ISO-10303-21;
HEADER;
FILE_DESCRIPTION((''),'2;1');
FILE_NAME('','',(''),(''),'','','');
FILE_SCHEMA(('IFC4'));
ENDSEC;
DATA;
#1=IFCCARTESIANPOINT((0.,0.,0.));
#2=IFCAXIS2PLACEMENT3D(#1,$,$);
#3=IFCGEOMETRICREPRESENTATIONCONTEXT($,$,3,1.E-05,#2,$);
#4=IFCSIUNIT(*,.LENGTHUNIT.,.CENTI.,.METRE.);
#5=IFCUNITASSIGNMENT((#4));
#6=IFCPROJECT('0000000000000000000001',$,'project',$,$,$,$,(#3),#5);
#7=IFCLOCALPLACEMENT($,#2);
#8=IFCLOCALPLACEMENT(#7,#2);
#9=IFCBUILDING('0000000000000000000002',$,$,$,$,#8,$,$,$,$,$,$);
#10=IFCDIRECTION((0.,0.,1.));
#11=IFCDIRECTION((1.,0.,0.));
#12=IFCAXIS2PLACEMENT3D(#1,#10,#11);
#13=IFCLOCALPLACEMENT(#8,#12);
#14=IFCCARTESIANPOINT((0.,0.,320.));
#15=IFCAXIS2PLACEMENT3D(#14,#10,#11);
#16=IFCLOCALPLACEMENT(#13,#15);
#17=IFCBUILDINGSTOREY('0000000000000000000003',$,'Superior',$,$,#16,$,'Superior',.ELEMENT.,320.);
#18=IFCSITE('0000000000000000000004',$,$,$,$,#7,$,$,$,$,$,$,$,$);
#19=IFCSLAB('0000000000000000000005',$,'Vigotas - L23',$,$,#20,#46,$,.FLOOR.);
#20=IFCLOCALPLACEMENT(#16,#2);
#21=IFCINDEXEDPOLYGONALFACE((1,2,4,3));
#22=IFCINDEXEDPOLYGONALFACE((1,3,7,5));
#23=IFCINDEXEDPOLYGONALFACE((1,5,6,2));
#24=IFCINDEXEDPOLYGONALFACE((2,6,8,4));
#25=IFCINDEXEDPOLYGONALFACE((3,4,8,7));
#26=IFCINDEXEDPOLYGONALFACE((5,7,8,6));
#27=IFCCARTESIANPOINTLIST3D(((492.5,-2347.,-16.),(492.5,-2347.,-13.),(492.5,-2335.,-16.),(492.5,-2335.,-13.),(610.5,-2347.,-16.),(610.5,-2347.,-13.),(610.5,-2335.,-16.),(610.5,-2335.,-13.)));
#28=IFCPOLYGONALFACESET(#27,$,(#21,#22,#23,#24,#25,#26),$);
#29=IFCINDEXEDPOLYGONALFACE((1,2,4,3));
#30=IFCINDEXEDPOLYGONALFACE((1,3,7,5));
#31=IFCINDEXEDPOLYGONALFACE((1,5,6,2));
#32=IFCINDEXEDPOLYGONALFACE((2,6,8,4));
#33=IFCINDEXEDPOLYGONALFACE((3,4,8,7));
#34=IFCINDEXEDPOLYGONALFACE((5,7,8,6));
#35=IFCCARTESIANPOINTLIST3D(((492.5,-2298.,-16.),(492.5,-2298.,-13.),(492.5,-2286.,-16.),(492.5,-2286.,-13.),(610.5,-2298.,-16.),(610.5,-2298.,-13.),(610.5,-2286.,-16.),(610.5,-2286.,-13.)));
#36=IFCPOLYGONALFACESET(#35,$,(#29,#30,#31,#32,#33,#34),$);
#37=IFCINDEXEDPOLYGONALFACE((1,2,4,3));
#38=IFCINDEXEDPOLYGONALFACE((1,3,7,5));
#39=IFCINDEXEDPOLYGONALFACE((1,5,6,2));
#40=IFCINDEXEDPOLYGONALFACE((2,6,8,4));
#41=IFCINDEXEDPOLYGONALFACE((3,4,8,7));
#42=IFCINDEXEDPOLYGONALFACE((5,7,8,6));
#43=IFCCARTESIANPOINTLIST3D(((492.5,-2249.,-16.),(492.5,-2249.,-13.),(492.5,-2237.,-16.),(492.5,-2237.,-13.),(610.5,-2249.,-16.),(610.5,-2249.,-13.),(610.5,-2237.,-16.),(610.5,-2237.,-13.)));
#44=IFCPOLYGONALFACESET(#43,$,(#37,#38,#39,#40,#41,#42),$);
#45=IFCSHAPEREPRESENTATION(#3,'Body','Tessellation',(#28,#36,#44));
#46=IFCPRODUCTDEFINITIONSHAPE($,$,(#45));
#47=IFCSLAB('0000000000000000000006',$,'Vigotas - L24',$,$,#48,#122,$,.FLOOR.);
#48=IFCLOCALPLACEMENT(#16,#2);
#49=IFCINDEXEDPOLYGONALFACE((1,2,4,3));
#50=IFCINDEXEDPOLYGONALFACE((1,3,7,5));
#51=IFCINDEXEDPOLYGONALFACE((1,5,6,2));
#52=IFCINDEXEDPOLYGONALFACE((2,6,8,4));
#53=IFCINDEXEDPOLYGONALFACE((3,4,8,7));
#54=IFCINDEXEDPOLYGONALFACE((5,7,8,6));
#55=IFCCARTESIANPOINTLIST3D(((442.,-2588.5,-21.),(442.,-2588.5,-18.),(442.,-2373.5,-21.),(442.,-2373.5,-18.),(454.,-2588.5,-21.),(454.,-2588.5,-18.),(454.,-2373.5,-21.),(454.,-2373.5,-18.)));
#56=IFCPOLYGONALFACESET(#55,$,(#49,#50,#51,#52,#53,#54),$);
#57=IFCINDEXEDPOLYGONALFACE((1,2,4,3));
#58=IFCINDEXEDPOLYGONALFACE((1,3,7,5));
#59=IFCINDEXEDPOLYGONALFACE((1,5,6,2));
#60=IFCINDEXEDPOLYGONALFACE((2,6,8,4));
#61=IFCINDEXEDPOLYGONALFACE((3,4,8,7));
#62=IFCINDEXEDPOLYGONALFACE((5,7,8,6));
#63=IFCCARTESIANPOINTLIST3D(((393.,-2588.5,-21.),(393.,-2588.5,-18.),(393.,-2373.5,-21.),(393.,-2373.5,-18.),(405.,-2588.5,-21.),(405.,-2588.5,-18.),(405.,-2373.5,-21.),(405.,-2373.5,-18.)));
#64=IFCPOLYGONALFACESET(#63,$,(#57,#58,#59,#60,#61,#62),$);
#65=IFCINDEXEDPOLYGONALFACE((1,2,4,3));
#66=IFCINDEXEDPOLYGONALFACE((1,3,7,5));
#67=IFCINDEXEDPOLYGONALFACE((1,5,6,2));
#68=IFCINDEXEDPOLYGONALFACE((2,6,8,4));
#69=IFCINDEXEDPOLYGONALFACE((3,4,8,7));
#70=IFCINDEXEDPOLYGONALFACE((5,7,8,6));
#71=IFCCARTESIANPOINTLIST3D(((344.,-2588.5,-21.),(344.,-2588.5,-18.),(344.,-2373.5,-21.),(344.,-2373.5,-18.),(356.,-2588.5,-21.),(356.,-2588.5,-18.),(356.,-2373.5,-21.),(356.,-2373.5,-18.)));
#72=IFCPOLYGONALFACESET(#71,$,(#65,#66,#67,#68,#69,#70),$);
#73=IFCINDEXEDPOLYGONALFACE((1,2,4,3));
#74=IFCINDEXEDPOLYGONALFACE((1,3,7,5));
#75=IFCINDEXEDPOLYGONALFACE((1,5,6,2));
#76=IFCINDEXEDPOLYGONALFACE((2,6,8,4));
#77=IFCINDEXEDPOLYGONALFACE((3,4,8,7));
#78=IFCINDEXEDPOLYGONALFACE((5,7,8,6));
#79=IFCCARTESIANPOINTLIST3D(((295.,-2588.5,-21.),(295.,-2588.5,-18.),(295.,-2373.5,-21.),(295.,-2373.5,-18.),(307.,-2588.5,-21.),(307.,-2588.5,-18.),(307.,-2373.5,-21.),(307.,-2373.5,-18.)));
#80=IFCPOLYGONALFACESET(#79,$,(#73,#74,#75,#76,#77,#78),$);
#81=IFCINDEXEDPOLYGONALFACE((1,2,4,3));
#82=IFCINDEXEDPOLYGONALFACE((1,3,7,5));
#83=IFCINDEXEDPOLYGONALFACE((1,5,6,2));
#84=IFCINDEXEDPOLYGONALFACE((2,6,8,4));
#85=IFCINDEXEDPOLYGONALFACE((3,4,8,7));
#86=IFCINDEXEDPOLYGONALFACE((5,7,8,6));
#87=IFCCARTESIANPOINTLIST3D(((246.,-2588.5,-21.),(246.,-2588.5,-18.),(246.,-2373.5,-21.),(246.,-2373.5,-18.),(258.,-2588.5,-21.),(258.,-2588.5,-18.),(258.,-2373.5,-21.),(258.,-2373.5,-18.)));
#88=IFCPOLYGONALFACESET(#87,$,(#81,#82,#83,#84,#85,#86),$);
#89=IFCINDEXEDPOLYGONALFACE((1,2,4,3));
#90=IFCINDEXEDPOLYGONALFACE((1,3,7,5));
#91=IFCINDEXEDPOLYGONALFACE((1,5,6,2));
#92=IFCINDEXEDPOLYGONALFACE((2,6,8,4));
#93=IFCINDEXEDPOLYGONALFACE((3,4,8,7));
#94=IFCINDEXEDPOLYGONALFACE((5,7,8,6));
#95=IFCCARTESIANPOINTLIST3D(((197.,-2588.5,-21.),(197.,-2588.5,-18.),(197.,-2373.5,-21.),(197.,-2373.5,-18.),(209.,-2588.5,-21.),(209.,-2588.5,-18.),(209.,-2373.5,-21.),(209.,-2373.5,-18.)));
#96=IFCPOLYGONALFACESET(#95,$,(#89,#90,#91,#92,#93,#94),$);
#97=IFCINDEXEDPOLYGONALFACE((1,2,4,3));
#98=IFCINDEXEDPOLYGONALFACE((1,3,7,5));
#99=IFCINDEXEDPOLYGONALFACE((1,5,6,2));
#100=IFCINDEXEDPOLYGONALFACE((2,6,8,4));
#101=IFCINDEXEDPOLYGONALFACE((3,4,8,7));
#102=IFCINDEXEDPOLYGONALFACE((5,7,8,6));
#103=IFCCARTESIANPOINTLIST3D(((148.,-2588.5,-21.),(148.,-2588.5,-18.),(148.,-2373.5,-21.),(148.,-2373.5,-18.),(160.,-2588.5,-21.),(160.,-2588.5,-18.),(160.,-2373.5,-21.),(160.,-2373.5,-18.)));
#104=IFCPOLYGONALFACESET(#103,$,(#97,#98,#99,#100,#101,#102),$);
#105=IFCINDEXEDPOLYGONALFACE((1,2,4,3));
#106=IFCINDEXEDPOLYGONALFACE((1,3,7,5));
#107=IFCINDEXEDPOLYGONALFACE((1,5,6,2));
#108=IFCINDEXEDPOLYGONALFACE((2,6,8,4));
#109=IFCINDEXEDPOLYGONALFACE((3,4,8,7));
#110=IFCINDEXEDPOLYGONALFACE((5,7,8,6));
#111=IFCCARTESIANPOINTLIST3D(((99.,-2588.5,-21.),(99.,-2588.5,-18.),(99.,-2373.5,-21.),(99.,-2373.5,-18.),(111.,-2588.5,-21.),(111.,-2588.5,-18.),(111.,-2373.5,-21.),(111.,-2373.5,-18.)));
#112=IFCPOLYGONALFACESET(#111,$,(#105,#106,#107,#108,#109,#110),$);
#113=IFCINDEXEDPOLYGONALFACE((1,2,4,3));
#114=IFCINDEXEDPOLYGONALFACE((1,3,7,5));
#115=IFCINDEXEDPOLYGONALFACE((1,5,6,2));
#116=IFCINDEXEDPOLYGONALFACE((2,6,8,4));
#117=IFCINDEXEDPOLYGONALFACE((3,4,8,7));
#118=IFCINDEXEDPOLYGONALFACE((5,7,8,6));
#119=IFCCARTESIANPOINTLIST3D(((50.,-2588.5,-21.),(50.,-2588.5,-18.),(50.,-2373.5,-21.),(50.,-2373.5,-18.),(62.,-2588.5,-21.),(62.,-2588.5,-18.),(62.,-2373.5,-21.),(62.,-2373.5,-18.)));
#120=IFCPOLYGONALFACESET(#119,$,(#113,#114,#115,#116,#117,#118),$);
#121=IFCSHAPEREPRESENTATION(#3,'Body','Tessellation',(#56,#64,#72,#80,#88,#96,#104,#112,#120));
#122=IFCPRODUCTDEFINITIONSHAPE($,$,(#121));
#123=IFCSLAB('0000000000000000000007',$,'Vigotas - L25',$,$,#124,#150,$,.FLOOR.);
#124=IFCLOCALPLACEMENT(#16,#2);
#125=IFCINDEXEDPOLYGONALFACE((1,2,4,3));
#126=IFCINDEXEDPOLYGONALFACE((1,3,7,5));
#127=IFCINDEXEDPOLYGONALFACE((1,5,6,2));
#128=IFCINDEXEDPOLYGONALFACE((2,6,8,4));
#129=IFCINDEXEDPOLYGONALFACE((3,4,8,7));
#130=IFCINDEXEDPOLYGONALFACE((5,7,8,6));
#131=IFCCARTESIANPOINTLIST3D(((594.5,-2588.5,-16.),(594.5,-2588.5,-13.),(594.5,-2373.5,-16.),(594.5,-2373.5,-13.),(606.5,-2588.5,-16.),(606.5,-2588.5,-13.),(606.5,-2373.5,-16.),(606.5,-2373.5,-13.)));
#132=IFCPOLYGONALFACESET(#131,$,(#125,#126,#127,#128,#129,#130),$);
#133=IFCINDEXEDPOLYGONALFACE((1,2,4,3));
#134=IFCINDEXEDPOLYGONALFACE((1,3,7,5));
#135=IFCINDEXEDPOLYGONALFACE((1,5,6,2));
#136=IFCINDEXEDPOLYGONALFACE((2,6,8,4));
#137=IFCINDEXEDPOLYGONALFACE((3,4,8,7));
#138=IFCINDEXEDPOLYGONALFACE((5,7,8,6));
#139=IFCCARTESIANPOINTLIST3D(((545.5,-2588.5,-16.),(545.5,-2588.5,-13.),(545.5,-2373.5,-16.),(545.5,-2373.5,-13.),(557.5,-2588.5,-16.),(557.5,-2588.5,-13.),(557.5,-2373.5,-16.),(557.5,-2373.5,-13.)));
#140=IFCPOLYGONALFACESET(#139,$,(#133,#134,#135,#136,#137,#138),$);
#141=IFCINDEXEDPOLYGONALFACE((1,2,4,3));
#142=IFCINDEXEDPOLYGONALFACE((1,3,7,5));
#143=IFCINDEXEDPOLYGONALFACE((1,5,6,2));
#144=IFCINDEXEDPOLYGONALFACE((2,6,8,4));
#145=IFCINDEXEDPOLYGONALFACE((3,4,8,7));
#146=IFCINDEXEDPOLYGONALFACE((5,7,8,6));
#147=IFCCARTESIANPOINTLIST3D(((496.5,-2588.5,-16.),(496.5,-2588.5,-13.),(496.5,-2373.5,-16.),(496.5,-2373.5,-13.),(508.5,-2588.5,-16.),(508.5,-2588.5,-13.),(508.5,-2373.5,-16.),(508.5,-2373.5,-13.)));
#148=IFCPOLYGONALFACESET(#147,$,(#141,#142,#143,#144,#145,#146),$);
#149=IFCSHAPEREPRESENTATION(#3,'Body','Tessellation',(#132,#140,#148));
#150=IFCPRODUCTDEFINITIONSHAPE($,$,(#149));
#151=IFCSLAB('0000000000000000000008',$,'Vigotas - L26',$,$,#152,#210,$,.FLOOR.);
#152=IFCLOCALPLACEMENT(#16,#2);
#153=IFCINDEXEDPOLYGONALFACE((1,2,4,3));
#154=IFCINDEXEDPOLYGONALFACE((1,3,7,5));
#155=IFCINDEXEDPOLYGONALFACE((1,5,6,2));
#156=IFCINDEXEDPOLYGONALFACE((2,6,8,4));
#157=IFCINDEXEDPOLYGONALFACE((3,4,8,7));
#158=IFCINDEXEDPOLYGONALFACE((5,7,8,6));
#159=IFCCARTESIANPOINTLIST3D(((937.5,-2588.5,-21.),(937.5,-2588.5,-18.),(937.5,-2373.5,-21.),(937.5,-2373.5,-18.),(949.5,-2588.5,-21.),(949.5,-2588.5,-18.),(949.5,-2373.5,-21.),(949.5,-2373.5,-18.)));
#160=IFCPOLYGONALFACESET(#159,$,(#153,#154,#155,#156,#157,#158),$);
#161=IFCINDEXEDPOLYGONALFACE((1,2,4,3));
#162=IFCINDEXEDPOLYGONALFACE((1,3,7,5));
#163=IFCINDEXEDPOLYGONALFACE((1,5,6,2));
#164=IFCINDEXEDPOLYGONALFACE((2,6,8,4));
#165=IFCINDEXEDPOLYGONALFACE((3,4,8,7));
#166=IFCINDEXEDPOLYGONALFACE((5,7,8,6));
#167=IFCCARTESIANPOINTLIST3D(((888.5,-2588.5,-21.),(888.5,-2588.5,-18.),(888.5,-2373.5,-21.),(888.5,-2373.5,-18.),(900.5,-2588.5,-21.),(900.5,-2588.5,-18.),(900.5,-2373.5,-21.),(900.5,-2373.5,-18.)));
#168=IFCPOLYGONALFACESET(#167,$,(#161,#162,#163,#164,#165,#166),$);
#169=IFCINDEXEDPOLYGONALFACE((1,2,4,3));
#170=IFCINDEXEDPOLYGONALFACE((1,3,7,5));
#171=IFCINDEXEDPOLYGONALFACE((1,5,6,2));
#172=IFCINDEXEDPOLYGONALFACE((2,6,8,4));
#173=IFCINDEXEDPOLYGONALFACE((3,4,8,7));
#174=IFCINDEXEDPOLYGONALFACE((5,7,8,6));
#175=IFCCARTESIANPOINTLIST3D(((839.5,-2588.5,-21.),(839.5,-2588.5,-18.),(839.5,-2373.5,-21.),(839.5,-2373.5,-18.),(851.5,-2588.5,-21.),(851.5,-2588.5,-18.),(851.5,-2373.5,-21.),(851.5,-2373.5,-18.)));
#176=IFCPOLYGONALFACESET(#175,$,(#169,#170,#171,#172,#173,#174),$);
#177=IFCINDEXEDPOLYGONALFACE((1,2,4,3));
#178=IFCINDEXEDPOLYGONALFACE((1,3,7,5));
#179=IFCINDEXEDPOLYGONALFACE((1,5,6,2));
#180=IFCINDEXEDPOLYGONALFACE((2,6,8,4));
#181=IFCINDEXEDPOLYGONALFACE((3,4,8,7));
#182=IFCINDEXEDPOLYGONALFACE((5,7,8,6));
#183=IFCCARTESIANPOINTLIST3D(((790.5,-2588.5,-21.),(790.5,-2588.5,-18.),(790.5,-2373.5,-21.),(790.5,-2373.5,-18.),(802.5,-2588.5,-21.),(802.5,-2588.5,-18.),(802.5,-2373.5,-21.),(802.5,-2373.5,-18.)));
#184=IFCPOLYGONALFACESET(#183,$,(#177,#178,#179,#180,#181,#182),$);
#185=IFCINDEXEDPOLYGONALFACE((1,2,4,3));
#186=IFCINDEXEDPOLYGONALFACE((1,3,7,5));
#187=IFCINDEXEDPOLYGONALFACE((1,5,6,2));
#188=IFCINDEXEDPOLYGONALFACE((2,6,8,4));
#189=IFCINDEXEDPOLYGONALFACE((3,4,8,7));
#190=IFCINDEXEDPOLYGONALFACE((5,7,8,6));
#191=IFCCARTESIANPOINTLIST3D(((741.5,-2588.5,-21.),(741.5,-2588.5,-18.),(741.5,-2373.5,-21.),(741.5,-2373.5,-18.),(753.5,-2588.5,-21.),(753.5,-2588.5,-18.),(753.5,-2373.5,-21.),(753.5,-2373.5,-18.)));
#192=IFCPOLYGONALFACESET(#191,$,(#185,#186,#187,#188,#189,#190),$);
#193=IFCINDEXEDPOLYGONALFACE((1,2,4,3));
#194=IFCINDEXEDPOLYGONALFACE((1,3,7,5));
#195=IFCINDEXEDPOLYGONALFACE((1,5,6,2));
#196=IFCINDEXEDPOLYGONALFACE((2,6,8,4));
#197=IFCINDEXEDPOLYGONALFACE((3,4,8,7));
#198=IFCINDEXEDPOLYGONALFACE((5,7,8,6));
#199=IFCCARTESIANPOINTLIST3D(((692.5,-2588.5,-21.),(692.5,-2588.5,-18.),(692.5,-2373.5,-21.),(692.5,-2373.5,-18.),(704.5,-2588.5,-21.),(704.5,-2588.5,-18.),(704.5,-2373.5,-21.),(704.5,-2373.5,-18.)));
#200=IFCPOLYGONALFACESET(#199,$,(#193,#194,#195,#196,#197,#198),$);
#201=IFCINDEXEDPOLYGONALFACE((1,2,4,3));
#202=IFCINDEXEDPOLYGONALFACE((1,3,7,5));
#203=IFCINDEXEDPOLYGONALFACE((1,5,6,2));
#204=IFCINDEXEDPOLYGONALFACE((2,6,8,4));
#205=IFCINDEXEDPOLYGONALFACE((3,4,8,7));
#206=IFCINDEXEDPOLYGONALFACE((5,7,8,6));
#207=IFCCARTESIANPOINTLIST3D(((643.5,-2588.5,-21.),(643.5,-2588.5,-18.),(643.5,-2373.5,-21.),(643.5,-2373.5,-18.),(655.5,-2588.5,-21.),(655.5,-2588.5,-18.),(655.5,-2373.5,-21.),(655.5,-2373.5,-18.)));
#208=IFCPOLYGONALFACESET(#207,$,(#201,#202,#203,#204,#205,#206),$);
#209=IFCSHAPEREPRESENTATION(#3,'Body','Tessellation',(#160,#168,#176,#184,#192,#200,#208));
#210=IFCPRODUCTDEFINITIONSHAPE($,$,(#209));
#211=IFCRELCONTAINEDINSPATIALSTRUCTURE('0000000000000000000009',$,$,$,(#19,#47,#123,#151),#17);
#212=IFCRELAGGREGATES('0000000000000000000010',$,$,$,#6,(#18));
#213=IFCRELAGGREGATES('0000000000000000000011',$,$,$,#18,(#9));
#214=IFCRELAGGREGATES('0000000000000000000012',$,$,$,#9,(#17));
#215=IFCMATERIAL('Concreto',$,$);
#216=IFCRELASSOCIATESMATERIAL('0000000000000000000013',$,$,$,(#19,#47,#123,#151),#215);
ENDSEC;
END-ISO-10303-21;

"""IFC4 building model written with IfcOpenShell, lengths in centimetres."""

from ifc_helpers import new_model, si_unit, frame, origin, origin_with_axes, place, context, project, spatial, polyline, outline, extrude, material, element, save


model = new_model("IFC4")

# Units and contexts
context_of_model = context(None, 3, precision=1e-05, world=origin())
ifc_project = project(units=[si_unit("LENGTHUNIT", "METRE", prefix="CENTI")], contexts=[context_of_model])

# Site, building, storey
site_placement = place(None, origin())
site = spatial("IfcSite", under=ifc_project, at=site_placement)
building_placement = place(site_placement, origin())
building = spatial("IfcBuilding", under=site, at=building_placement)
placement = place(building_placement, origin_with_axes())
storey_placement = place(placement, frame((0.0, 0.0, 320.0), z_axis=(0.0, 0.0, 1.0), x_axis=(1.0, 0.0, 0.0)))
storey = spatial("IfcBuildingStorey", under=building, at=storey_placement, Name="Superior", LongName="Superior", CompositionType="ELEMENT", Elevation=320.0)

# Shared definitions
ifc_material = material(Name="Concreto")

# Slabs
slab_1_placement = place(storey_placement, frame((551.5, -2292.0, -13.0), z_axis=(0.0, 0.0, 1.0), x_axis=(1.0, 0.0, 0.0)))
element("IfcSlab", 1, at=slab_1_placement, inside=storey, material=ifc_material, Name="Vigotas - L23", PredefinedType="FLOOR", context=context_of_model, shape_type="SolidModel", body=[
    extrude(outline(polyline([(6.0, 1.5), (-6.0, 1.5), (-6.0, -1.5), (6.0, -1.5), (6.0, 1.5), (6.0, 1.5)])), frame((-59.0, -49.0, -1.5), z_axis=(1.0, 0.0, 0.0), x_axis=(0.0, -1.0, 0.0)), (0.0, 0.0, 1.0), 118.0),
    extrude(outline(polyline([(6.0, 1.5), (-6.0, 1.5), (-6.0, -1.5), (6.0, -1.5), (6.0, 1.5), (6.0, 1.5)])), frame((-59.0, 0.0, -1.5), z_axis=(1.0, 0.0, 0.0), x_axis=(0.0, -1.0, 0.0)), (0.0, 0.0, 1.0), 118.0),
    extrude(outline(polyline([(6.0, 1.5), (-6.0, 1.5), (-6.0, -1.5), (6.0, -1.5), (6.0, 1.5), (6.0, 1.5)])), frame((-59.0, 49.0, -1.5), z_axis=(1.0, 0.0, 0.0), x_axis=(0.0, -1.0, 0.0)), (0.0, 0.0, 1.0), 118.0),
])
slab_2_placement = place(storey_placement, frame((252.0, -2481.0, -18.0), z_axis=(0.0, 0.0, 1.0), x_axis=(1.0, 0.0, 0.0)))
element("IfcSlab", 2, at=slab_2_placement, inside=storey, material=ifc_material, Name="Vigotas - L24", PredefinedType="FLOOR", context=context_of_model, shape_type="SolidModel", body=[
    extrude(outline(polyline([(6.0, 1.5), (-6.0, 1.5), (-6.0, -1.5), (6.0, -1.5), (6.0, 1.5), (6.0, 1.5)])), frame((196.0, -107.5, -1.5), z_axis=(0.0, 1.0, 0.0), x_axis=(1.0, 0.0, 0.0)), (0.0, 0.0, 1.0), 215.0),
    extrude(outline(polyline([(6.0, 1.5), (-6.0, 1.5), (-6.0, -1.5), (6.0, -1.5), (6.0, 1.5), (6.0, 1.5)])), frame((147.0, -107.5, -1.5), z_axis=(0.0, 1.0, 0.0), x_axis=(1.0, 0.0, 0.0)), (0.0, 0.0, 1.0), 215.0),
    extrude(outline(polyline([(6.0, 1.5), (-6.0, 1.5), (-6.0, -1.5), (6.0, -1.5), (6.0, 1.5), (6.0, 1.5)])), frame((98.0, -107.5, -1.5), z_axis=(0.0, 1.0, 0.0), x_axis=(1.0, 0.0, 0.0)), (0.0, 0.0, 1.0), 215.0),
    extrude(outline(polyline([(6.0, 1.5), (-6.0, 1.5), (-6.0, -1.5), (6.0, -1.5), (6.0, 1.5), (6.0, 1.5)])), frame((49.0, -107.5, -1.5), z_axis=(0.0, 1.0, 0.0), x_axis=(1.0, 0.0, 0.0)), (0.0, 0.0, 1.0), 215.0),
    extrude(outline(polyline([(6.0, 1.5), (-6.0, 1.5), (-6.0, -1.5), (6.0, -1.5), (6.0, 1.5), (6.0, 1.5)])), frame((0.0, -107.5, -1.5), z_axis=(0.0, 1.0, 0.0), x_axis=(1.0, 0.0, 0.0)), (0.0, 0.0, 1.0), 215.0),
    extrude(outline(polyline([(6.0, 1.5), (-6.0, 1.5), (-6.0, -1.5), (6.0, -1.5), (6.0, 1.5), (6.0, 1.5)])), frame((-49.0, -107.5, -1.5), z_axis=(0.0, 1.0, 0.0), x_axis=(1.0, 0.0, 0.0)), (0.0, 0.0, 1.0), 215.0),
    extrude(outline(polyline([(6.0, 1.5), (-6.0, 1.5), (-6.0, -1.5), (6.0, -1.5), (6.0, 1.5), (6.0, 1.5)])), frame((-98.0, -107.5, -1.5), z_axis=(0.0, 1.0, 0.0), x_axis=(1.0, 0.0, 0.0)), (0.0, 0.0, 1.0), 215.0),
    extrude(outline(polyline([(6.0, 1.5), (-6.0, 1.5), (-6.0, -1.5), (6.0, -1.5), (6.0, 1.5), (6.0, 1.5)])), frame((-147.0, -107.5, -1.5), z_axis=(0.0, 1.0, 0.0), x_axis=(1.0, 0.0, 0.0)), (0.0, 0.0, 1.0), 215.0),
    extrude(outline(polyline([(6.0, 1.5), (-6.0, 1.5), (-6.0, -1.5), (6.0, -1.5), (6.0, 1.5), (6.0, 1.5)])), frame((-196.0, -107.5, -1.5), z_axis=(0.0, 1.0, 0.0), x_axis=(1.0, 0.0, 0.0)), (0.0, 0.0, 1.0), 215.0),
])
slab_3_placement = place(storey_placement, frame((551.5, -2481.0, -13.0), z_axis=(0.0, 0.0, 1.0), x_axis=(1.0, 0.0, 0.0)))
element("IfcSlab", 3, at=slab_3_placement, inside=storey, material=ifc_material, Name="Vigotas - L25", PredefinedType="FLOOR", context=context_of_model, shape_type="SolidModel", body=[
    extrude(outline(polyline([(6.0, 1.5), (-6.0, 1.5), (-6.0, -1.5), (6.0, -1.5), (6.0, 1.5), (6.0, 1.5)])), frame((49.0, -107.5, -1.5), z_axis=(0.0, 1.0, 0.0), x_axis=(1.0, 0.0, 0.0)), (0.0, 0.0, 1.0), 215.0),
    extrude(outline(polyline([(6.0, 1.5), (-6.0, 1.5), (-6.0, -1.5), (6.0, -1.5), (6.0, 1.5), (6.0, 1.5)])), frame((0.0, -107.5, -1.5), z_axis=(0.0, 1.0, 0.0), x_axis=(1.0, 0.0, 0.0)), (0.0, 0.0, 1.0), 215.0),
    extrude(outline(polyline([(6.0, 1.5), (-6.0, 1.5), (-6.0, -1.5), (6.0, -1.5), (6.0, 1.5), (6.0, 1.5)])), frame((-49.0, -107.5, -1.5), z_axis=(0.0, 1.0, 0.0), x_axis=(1.0, 0.0, 0.0)), (0.0, 0.0, 1.0), 215.0),
])
slab_4_placement = place(storey_placement, frame((796.5, -2481.0, -18.0), z_axis=(0.0, 0.0, 1.0), x_axis=(1.0, 0.0, 0.0)))
element("IfcSlab", 4, at=slab_4_placement, inside=storey, material=ifc_material, Name="Vigotas - L26", PredefinedType="FLOOR", context=context_of_model, shape_type="SolidModel", body=[
    extrude(outline(polyline([(6.0, 1.5), (-6.0, 1.5), (-6.0, -1.5), (6.0, -1.5), (6.0, 1.5), (6.0, 1.5)])), frame((147.0, -107.5, -1.5), z_axis=(0.0, 1.0, 0.0), x_axis=(1.0, 0.0, 0.0)), (0.0, 0.0, 1.0), 215.0),
    extrude(outline(polyline([(6.0, 1.5), (-6.0, 1.5), (-6.0, -1.5), (6.0, -1.5), (6.0, 1.5), (6.0, 1.5)])), frame((98.0, -107.5, -1.5), z_axis=(0.0, 1.0, 0.0), x_axis=(1.0, 0.0, 0.0)), (0.0, 0.0, 1.0), 215.0),
    extrude(outline(polyline([(6.0, 1.5), (-6.0, 1.5), (-6.0, -1.5), (6.0, -1.5), (6.0, 1.5), (6.0, 1.5)])), frame((49.0, -107.5, -1.5), z_axis=(0.0, 1.0, 0.0), x_axis=(1.0, 0.0, 0.0)), (0.0, 0.0, 1.0), 215.0),
    extrude(outline(polyline([(6.0, 1.5), (-6.0, 1.5), (-6.0, -1.5), (6.0, -1.5), (6.0, 1.5), (6.0, 1.5)])), frame((0.0, -107.5, -1.5), z_axis=(0.0, 1.0, 0.0), x_axis=(1.0, 0.0, 0.0)), (0.0, 0.0, 1.0), 215.0),
    extrude(outline(polyline([(6.0, 1.5), (-6.0, 1.5), (-6.0, -1.5), (6.0, -1.5), (6.0, 1.5), (6.0, 1.5)])), frame((-49.0, -107.5, -1.5), z_axis=(0.0, 1.0, 0.0), x_axis=(1.0, 0.0, 0.0)), (0.0, 0.0, 1.0), 215.0),
    extrude(outline(polyline([(6.0, 1.5), (-6.0, 1.5), (-6.0, -1.5), (6.0, -1.5), (6.0, 1.5), (6.0, 1.5)])), frame((-98.0, -107.5, -1.5), z_axis=(0.0, 1.0, 0.0), x_axis=(1.0, 0.0, 0.0)), (0.0, 0.0, 1.0), 215.0),
    extrude(outline(polyline([(6.0, 1.5), (-6.0, 1.5), (-6.0, -1.5), (6.0, -1.5), (6.0, 1.5), (6.0, 1.5)])), frame((-147.0, -107.5, -1.5), z_axis=(0.0, 1.0, 0.0), x_axis=(1.0, 0.0, 0.0)), (0.0, 0.0, 1.0), 215.0),
])

save(model, "model.ifc")
